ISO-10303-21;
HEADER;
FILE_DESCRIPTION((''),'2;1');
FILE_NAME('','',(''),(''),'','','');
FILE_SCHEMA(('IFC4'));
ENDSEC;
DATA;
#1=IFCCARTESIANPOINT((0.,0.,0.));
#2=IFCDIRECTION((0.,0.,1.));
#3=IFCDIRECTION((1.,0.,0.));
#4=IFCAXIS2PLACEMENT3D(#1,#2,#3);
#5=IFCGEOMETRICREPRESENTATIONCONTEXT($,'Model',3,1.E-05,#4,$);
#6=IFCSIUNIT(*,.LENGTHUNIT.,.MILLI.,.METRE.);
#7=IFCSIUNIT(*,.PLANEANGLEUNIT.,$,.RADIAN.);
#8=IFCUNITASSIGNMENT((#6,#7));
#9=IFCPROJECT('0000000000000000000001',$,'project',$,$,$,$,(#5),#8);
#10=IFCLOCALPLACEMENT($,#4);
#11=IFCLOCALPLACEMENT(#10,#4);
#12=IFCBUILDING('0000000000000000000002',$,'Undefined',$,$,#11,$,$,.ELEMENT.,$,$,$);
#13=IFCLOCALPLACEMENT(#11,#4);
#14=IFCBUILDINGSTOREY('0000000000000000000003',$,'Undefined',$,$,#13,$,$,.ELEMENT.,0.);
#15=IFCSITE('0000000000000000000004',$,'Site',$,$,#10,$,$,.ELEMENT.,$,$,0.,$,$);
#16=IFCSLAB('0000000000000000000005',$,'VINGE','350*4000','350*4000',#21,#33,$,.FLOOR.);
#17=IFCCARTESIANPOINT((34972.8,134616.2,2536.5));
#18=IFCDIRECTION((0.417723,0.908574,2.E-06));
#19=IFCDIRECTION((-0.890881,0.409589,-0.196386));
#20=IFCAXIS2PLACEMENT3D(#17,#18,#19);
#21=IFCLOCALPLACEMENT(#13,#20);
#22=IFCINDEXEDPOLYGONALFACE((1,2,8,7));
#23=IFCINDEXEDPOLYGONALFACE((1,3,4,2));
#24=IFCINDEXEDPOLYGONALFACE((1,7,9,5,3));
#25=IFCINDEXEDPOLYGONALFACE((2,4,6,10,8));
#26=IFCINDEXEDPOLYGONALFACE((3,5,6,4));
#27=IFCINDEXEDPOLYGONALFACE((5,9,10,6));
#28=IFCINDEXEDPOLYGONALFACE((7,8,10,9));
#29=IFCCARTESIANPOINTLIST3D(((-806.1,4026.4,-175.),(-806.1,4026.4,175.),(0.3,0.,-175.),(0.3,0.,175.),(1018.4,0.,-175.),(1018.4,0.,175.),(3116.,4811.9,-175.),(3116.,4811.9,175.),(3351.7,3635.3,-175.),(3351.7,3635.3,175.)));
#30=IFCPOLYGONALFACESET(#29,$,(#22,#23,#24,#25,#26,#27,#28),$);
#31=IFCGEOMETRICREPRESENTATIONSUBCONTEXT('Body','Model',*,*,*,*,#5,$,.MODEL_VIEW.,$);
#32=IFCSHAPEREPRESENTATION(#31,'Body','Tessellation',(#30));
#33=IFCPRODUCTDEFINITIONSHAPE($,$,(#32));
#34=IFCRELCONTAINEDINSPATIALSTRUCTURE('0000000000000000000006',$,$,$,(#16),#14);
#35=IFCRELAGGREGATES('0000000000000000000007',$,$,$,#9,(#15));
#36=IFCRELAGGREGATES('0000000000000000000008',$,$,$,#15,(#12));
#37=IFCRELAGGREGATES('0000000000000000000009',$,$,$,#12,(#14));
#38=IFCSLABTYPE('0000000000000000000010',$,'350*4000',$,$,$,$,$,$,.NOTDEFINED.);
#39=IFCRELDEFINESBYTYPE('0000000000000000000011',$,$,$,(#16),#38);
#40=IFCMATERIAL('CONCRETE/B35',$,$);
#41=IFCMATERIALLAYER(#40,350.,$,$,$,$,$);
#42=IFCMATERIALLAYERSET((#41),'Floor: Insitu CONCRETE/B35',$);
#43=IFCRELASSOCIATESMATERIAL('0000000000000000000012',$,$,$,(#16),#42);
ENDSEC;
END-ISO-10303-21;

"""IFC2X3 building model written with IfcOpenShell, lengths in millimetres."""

from ifc_helpers import new_model, si_unit, frame, origin_with_axes, place, context, subcontext, project, spatial, polyline, outline, extrude, material, layer, layer_set, layer_usage, type_object, element, save


model = new_model("IFC2X3")

# Units and contexts
model_context = context("Model", 3, precision=1e-05, world=origin_with_axes())
body_context = subcontext(model_context, "Body", "Model", "MODEL_VIEW")
ifc_project = project(units=[si_unit("LENGTHUNIT", "METRE", prefix="MILLI"), si_unit("PLANEANGLEUNIT", "RADIAN")], contexts=[model_context])

# Site, building, storey
site_placement = place(None, origin_with_axes())
site = spatial("IfcSite", under=ifc_project, at=site_placement, Name="Site", CompositionType="ELEMENT", RefElevation=0.0)
building_placement = place(site_placement, origin_with_axes())
building = spatial("IfcBuilding", under=site, at=building_placement, Name="Undefined", CompositionType="ELEMENT")
storey_placement = place(building_placement, origin_with_axes())
storey = spatial("IfcBuildingStorey", under=building, at=storey_placement, Name="Undefined", CompositionType="ELEMENT", Elevation=0.0)

# Shared definitions
ifc_material_1 = material(Name="CONCRETE/B35")

# Slab
ifc_layer_1 = layer(ifc_material_1, 350.0)
ifc_layer_set_1 = layer_set([ifc_layer_1], Name="Floor: Insitu CONCRETE/B35")
ifc_layer_usage_1 = layer_usage(ifc_layer_set_1, "AXIS3", "POSITIVE", -175.0)
slab_type_1 = type_object("IfcSlabType", Name="350*4000", PredefinedType="NOTDEFINED")
slab_1_placement = place(storey_placement, frame((34972.8, 134616.2, 2536.5), z_axis=(0.417723, 0.908574, 0.000002), x_axis=(-0.890881, 0.409589, -0.196386)))
element("IfcSlab", 1, at=slab_1_placement, inside=storey, type_object=slab_type_1, material=ifc_layer_usage_1, Name="VINGE", Description="350*4000", ObjectType="350*4000", PredefinedType="FLOOR", context=body_context, shape_type="SweptSolid", body=[
    extrude(outline(polyline([(0.0, 0.0), (1018.4, 0.0), (3351.7, 3635.3), (3116.0, 4811.9), (-806.1, 4026.4), (0.3, 0.1), (0.0, 0.0)])), frame((0.0, 0.0, -175.0), z_axis=(0.0, 0.0, 1.0), x_axis=(1.0, 0.0, 0.0)), (0.0, 0.0, 1.0), 350.0),
])

save(model, "model.ifc")
